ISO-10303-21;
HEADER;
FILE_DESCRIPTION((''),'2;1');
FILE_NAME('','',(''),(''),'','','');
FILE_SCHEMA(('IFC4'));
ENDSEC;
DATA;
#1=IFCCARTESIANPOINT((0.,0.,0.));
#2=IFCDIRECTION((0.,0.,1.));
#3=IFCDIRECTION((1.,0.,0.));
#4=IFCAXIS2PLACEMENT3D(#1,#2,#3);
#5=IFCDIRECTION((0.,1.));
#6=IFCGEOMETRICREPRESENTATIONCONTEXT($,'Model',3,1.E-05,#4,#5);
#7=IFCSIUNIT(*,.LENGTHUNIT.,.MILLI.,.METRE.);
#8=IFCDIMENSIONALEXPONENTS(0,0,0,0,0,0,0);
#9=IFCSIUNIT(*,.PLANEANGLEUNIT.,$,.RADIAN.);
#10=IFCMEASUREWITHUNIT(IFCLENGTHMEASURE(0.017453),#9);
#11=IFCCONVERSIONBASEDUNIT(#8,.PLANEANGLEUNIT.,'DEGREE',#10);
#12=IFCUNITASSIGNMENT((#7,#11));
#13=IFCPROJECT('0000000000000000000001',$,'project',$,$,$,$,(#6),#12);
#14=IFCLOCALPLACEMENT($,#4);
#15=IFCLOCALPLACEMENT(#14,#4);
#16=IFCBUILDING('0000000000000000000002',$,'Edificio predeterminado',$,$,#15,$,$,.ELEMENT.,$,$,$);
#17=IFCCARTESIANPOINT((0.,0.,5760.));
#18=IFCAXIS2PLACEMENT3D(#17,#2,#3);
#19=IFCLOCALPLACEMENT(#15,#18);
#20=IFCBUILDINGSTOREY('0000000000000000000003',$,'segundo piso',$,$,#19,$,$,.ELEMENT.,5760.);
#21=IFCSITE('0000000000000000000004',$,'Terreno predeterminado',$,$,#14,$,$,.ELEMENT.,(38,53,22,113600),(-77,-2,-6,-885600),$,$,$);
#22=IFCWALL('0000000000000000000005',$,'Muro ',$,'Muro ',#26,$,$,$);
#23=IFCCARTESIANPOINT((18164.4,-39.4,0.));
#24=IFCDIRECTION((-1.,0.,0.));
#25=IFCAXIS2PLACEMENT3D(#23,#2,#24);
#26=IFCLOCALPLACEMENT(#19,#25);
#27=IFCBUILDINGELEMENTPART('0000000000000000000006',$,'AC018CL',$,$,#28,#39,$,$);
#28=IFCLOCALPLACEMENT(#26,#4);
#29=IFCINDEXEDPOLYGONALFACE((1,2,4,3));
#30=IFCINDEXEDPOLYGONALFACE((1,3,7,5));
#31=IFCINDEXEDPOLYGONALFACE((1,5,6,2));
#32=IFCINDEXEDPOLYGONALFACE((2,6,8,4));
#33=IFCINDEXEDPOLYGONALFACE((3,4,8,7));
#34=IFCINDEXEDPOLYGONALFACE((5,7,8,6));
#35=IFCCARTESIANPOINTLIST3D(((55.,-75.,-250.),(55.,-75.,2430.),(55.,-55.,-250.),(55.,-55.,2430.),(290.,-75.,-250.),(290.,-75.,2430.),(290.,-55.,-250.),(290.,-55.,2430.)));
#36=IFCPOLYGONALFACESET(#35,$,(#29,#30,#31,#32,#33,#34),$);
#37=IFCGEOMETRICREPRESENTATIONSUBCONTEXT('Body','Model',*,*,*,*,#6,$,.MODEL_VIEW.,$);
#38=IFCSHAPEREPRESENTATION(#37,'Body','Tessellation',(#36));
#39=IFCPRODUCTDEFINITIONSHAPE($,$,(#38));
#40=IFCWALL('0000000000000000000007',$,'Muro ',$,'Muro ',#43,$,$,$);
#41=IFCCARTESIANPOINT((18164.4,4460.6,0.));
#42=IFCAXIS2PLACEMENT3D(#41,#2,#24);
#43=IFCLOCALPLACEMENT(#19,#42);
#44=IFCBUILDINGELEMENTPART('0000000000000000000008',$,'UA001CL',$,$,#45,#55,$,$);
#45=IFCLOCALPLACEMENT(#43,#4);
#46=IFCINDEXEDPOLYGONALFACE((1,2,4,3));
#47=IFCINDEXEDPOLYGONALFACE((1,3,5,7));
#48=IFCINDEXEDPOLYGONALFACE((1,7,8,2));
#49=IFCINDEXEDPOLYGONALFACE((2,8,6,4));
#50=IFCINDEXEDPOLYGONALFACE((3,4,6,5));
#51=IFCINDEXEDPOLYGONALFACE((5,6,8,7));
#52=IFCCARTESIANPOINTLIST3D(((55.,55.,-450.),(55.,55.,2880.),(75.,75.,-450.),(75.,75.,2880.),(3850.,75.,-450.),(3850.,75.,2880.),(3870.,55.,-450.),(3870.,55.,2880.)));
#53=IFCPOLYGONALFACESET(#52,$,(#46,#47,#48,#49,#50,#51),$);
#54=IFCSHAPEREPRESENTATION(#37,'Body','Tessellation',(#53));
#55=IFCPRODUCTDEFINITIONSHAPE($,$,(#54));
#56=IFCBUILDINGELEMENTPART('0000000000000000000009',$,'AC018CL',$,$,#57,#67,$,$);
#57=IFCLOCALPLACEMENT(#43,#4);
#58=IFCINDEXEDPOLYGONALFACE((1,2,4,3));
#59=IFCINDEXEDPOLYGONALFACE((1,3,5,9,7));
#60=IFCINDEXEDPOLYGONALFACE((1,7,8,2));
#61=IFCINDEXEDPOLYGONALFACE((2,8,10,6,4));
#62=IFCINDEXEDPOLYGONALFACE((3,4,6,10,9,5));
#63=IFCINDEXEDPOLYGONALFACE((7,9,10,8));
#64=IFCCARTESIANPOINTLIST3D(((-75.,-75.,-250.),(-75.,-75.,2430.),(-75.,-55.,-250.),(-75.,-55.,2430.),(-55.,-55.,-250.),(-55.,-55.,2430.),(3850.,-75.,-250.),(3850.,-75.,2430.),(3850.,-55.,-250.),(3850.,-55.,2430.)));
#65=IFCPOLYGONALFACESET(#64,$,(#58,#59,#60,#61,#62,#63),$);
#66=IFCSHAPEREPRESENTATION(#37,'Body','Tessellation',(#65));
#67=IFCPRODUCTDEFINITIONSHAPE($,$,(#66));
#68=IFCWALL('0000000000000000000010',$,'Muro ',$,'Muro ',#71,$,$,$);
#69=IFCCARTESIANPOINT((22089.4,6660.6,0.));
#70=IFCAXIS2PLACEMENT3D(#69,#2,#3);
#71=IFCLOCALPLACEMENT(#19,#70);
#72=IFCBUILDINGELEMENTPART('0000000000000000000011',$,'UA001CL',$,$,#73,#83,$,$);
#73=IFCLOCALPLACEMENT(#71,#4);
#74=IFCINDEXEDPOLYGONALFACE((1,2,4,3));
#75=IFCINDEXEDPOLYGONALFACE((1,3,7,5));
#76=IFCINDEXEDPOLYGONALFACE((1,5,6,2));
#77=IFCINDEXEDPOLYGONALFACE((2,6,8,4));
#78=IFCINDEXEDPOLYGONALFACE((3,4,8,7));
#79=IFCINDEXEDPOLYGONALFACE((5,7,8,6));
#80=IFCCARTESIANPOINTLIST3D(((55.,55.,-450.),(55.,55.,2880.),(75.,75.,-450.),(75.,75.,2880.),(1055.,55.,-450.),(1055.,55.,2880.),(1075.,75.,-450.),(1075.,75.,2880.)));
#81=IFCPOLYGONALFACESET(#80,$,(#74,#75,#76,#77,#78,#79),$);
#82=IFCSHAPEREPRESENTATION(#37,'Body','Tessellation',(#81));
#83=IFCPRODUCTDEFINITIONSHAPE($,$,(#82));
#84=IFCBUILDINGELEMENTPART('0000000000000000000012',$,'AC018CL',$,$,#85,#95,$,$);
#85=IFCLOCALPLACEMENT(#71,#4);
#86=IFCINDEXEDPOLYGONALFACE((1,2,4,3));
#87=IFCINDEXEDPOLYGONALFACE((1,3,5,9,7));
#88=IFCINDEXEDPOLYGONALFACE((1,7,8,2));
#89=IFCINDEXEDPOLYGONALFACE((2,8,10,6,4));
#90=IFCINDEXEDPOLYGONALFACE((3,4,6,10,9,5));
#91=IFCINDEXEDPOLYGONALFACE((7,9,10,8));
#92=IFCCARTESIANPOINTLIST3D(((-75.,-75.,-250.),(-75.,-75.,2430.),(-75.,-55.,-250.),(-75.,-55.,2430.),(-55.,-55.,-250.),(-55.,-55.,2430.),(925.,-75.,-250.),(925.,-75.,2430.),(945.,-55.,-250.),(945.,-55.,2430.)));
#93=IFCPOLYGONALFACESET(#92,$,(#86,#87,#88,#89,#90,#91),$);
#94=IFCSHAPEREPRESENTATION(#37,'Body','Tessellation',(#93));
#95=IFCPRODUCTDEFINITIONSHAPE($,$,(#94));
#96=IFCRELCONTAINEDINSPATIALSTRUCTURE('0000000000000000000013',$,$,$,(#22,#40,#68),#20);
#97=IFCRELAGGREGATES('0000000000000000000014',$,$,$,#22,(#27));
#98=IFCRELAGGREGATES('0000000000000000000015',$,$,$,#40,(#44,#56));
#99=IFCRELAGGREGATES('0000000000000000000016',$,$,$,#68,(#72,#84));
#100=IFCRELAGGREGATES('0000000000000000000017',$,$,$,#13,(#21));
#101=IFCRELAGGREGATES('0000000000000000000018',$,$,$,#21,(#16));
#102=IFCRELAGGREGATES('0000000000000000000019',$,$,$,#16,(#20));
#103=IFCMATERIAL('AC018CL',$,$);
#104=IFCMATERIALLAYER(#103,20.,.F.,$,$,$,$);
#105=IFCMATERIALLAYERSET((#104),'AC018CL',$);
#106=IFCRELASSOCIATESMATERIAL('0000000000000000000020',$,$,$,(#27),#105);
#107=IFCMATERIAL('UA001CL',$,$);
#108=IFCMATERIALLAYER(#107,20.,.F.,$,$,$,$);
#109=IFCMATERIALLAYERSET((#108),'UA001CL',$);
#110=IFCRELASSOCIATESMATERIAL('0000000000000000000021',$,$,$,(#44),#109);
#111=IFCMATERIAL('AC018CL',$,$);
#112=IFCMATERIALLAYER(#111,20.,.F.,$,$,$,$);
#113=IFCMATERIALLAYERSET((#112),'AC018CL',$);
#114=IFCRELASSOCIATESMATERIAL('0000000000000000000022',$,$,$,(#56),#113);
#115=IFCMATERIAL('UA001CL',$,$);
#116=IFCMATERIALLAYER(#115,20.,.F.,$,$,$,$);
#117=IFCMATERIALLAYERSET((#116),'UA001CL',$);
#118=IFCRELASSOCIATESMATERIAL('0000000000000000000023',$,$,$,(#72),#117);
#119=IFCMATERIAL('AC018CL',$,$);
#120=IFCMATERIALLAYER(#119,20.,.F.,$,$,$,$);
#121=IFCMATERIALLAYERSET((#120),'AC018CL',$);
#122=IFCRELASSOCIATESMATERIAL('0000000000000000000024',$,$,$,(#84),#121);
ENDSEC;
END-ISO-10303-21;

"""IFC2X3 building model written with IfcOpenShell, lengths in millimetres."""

from ifc_helpers import new_model, entity, si_unit, converted_unit, direction, frame, origin_with_axes, place, context, subcontext, project, spatial, polyline, outline, extrude, material, layer, layer_set, layer_usage, element, aggregate, save


model = new_model("IFC2X3")

# Units and contexts
model_context = context("Model", 3, precision=1e-05, world=origin_with_axes(), true_north=direction((0.0, 1.0)))
body_context = subcontext(model_context, "Body", "Model", "MODEL_VIEW")
ifc_project = project(units=[si_unit("LENGTHUNIT", "METRE", prefix="MILLI"), converted_unit("PLANEANGLEUNIT", "DEGREE", entity("IfcLengthMeasure", 0.017453), si_unit("PLANEANGLEUNIT", "RADIAN"), dimensions=[0, 0, 0, 0, 0, 0, 0])], contexts=[model_context])

# Site, building, storey
site_placement = place(None, origin_with_axes())
site = spatial("IfcSite", under=ifc_project, at=site_placement, Name="Terreno predeterminado", CompositionType="ELEMENT", RefLatitude=(38, 53, 22, 113600), RefLongitude=(-77, -2, -6, -885600))
building_placement = place(site_placement, origin_with_axes())
building = spatial("IfcBuilding", under=site, at=building_placement, Name="Edificio predeterminado", CompositionType="ELEMENT")
storey_placement = place(building_placement, frame((0.0, 0.0, 5760.0), z_axis=(0.0, 0.0, 1.0), x_axis=(1.0, 0.0, 0.0)))
storey = spatial("IfcBuildingStorey", under=building, at=storey_placement, Name="segundo piso", CompositionType="ELEMENT", Elevation=5760.0)

# Wall, building element part
wall_1_placement = place(storey_placement, frame((18164.4, -39.4, 0.0), z_axis=(0.0, 0.0, 1.0), x_axis=(-1.0, 0.0, 0.0)))
wall_1 = element("IfcWall", 1, at=wall_1_placement, inside=storey, Name="Muro ", ObjectType="Muro ")
ifc_material_1 = material(Name="AC018CL")
ifc_layer_1 = layer(ifc_material_1, 20.0, ventilated=False)
ifc_layer_set_1 = layer_set([ifc_layer_1], Name="AC018CL")
ifc_layer_usage_1 = layer_usage(ifc_layer_set_1, "AXIS2", "NEGATIVE", 55.0)
building_element_part_1_placement = place(wall_1_placement, origin_with_axes())
building_element_part_1 = element("IfcBuildingElementPart", 2, at=building_element_part_1_placement, material=ifc_layer_usage_1, Name="AC018CL", context=body_context, shape_type="SweptSolid", body=[
    extrude(outline(polyline([(290.0, -55.0), (290.0, -75.0), (55.0, -75.0), (55.0, -55.0), (290.0, -55.0)])), frame((0.0, 0.0, -250.0), z_axis=(0.0, 0.0, 1.0), x_axis=(1.0, 0.0, 0.0)), (0.0, 0.0, 1.0), 2680.0),
])
aggregate(wall_1, [building_element_part_1])

# Walls, building element parts
wall_2_placement = place(storey_placement, frame((18164.4, 4460.6, 0.0), z_axis=(0.0, 0.0, 1.0), x_axis=(-1.0, 0.0, 0.0)))
wall_2 = element("IfcWall", 3, at=wall_2_placement, inside=storey, Name="Muro ", ObjectType="Muro ")
ifc_material_2 = material(Name="UA001CL")
ifc_layer_2 = layer(ifc_material_2, 20.0, ventilated=False)
ifc_layer_set_2 = layer_set([ifc_layer_2], Name="UA001CL")
ifc_layer_usage_2 = layer_usage(ifc_layer_set_2, "AXIS2", "NEGATIVE", -75.0)
building_element_part_2_placement = place(wall_2_placement, origin_with_axes())
building_element_part_2 = element("IfcBuildingElementPart", 4, at=building_element_part_2_placement, material=ifc_layer_usage_2, Name="UA001CL", context=body_context, shape_type="SweptSolid", body=[
    extrude(outline(polyline([(3850.0, 75.0), (3870.0, 55.0), (55.0, 55.0), (75.0, 75.0), (3850.0, 75.0)])), frame((0.0, 0.0, -450.0), z_axis=(0.0, 0.0, 1.0), x_axis=(1.0, 0.0, 0.0)), (0.0, 0.0, 1.0), 3330.0),
])
ifc_material_3 = material(Name="AC018CL")
ifc_layer_3 = layer(ifc_material_3, 20.0, ventilated=False)
ifc_layer_set_3 = layer_set([ifc_layer_3], Name="AC018CL")
ifc_layer_usage_3 = layer_usage(ifc_layer_set_3, "AXIS2", "NEGATIVE", 55.0)
building_element_part_3_placement = place(wall_2_placement, origin_with_axes())
building_element_part_3 = element("IfcBuildingElementPart", 5, at=building_element_part_3_placement, material=ifc_layer_usage_3, Name="AC018CL", context=body_context, shape_type="SweptSolid", body=[
    extrude(outline(polyline([(3850.0, -55.0), (3850.0, -75.0), (-75.0, -75.0), (-75.0, -55.0), (-55.0, -55.0), (3850.0, -55.0)])), frame((0.0, 0.0, -250.0), z_axis=(0.0, 0.0, 1.0), x_axis=(1.0, 0.0, 0.0)), (0.0, 0.0, 1.0), 2680.0),
])
aggregate(wall_2, [building_element_part_2, building_element_part_3])
wall_3_placement = place(storey_placement, frame((22089.4, 6660.6, 0.0), z_axis=(0.0, 0.0, 1.0), x_axis=(1.0, 0.0, 0.0)))
wall_3 = element("IfcWall", 6, at=wall_3_placement, inside=storey, Name="Muro ", ObjectType="Muro ")
ifc_material_4 = material(Name="UA001CL")
ifc_layer_4 = layer(ifc_material_4, 20.0, ventilated=False)
ifc_layer_set_4 = layer_set([ifc_layer_4], Name="UA001CL")
ifc_layer_usage_4 = layer_usage(ifc_layer_set_4, "AXIS2", "NEGATIVE", -75.0)
building_element_part_4_placement = place(wall_3_placement, origin_with_axes())
building_element_part_4 = element("IfcBuildingElementPart", 7, at=building_element_part_4_placement, material=ifc_layer_usage_4, Name="UA001CL", context=body_context, shape_type="SweptSolid", body=[
    extrude(outline(polyline([(1075.0, 75.0), (1055.0, 55.0), (55.0, 55.0), (75.0, 75.0), (1075.0, 75.0)])), frame((0.0, 0.0, -450.0), z_axis=(0.0, 0.0, 1.0), x_axis=(1.0, 0.0, 0.0)), (0.0, 0.0, 1.0), 3330.0),
])
ifc_material_5 = material(Name="AC018CL")
ifc_layer_5 = layer(ifc_material_5, 20.0, ventilated=False)
ifc_layer_set_5 = layer_set([ifc_layer_5], Name="AC018CL")
ifc_layer_usage_5 = layer_usage(ifc_layer_set_5, "AXIS2", "NEGATIVE", 55.0)
building_element_part_5_placement = place(wall_3_placement, origin_with_axes())
building_element_part_5 = element("IfcBuildingElementPart", 8, at=building_element_part_5_placement, material=ifc_layer_usage_5, Name="AC018CL", context=body_context, shape_type="SweptSolid", body=[
    extrude(outline(polyline([(945.0, -55.0), (925.0, -75.0), (-75.0, -75.0), (-75.0, -55.0), (-55.0, -55.0), (945.0, -55.0)])), frame((0.0, 0.0, -250.0), z_axis=(0.0, 0.0, 1.0), x_axis=(1.0, 0.0, 0.0)), (0.0, 0.0, 1.0), 2680.0),
])
aggregate(wall_3, [building_element_part_4, building_element_part_5])

save(model, "model.ifc")
